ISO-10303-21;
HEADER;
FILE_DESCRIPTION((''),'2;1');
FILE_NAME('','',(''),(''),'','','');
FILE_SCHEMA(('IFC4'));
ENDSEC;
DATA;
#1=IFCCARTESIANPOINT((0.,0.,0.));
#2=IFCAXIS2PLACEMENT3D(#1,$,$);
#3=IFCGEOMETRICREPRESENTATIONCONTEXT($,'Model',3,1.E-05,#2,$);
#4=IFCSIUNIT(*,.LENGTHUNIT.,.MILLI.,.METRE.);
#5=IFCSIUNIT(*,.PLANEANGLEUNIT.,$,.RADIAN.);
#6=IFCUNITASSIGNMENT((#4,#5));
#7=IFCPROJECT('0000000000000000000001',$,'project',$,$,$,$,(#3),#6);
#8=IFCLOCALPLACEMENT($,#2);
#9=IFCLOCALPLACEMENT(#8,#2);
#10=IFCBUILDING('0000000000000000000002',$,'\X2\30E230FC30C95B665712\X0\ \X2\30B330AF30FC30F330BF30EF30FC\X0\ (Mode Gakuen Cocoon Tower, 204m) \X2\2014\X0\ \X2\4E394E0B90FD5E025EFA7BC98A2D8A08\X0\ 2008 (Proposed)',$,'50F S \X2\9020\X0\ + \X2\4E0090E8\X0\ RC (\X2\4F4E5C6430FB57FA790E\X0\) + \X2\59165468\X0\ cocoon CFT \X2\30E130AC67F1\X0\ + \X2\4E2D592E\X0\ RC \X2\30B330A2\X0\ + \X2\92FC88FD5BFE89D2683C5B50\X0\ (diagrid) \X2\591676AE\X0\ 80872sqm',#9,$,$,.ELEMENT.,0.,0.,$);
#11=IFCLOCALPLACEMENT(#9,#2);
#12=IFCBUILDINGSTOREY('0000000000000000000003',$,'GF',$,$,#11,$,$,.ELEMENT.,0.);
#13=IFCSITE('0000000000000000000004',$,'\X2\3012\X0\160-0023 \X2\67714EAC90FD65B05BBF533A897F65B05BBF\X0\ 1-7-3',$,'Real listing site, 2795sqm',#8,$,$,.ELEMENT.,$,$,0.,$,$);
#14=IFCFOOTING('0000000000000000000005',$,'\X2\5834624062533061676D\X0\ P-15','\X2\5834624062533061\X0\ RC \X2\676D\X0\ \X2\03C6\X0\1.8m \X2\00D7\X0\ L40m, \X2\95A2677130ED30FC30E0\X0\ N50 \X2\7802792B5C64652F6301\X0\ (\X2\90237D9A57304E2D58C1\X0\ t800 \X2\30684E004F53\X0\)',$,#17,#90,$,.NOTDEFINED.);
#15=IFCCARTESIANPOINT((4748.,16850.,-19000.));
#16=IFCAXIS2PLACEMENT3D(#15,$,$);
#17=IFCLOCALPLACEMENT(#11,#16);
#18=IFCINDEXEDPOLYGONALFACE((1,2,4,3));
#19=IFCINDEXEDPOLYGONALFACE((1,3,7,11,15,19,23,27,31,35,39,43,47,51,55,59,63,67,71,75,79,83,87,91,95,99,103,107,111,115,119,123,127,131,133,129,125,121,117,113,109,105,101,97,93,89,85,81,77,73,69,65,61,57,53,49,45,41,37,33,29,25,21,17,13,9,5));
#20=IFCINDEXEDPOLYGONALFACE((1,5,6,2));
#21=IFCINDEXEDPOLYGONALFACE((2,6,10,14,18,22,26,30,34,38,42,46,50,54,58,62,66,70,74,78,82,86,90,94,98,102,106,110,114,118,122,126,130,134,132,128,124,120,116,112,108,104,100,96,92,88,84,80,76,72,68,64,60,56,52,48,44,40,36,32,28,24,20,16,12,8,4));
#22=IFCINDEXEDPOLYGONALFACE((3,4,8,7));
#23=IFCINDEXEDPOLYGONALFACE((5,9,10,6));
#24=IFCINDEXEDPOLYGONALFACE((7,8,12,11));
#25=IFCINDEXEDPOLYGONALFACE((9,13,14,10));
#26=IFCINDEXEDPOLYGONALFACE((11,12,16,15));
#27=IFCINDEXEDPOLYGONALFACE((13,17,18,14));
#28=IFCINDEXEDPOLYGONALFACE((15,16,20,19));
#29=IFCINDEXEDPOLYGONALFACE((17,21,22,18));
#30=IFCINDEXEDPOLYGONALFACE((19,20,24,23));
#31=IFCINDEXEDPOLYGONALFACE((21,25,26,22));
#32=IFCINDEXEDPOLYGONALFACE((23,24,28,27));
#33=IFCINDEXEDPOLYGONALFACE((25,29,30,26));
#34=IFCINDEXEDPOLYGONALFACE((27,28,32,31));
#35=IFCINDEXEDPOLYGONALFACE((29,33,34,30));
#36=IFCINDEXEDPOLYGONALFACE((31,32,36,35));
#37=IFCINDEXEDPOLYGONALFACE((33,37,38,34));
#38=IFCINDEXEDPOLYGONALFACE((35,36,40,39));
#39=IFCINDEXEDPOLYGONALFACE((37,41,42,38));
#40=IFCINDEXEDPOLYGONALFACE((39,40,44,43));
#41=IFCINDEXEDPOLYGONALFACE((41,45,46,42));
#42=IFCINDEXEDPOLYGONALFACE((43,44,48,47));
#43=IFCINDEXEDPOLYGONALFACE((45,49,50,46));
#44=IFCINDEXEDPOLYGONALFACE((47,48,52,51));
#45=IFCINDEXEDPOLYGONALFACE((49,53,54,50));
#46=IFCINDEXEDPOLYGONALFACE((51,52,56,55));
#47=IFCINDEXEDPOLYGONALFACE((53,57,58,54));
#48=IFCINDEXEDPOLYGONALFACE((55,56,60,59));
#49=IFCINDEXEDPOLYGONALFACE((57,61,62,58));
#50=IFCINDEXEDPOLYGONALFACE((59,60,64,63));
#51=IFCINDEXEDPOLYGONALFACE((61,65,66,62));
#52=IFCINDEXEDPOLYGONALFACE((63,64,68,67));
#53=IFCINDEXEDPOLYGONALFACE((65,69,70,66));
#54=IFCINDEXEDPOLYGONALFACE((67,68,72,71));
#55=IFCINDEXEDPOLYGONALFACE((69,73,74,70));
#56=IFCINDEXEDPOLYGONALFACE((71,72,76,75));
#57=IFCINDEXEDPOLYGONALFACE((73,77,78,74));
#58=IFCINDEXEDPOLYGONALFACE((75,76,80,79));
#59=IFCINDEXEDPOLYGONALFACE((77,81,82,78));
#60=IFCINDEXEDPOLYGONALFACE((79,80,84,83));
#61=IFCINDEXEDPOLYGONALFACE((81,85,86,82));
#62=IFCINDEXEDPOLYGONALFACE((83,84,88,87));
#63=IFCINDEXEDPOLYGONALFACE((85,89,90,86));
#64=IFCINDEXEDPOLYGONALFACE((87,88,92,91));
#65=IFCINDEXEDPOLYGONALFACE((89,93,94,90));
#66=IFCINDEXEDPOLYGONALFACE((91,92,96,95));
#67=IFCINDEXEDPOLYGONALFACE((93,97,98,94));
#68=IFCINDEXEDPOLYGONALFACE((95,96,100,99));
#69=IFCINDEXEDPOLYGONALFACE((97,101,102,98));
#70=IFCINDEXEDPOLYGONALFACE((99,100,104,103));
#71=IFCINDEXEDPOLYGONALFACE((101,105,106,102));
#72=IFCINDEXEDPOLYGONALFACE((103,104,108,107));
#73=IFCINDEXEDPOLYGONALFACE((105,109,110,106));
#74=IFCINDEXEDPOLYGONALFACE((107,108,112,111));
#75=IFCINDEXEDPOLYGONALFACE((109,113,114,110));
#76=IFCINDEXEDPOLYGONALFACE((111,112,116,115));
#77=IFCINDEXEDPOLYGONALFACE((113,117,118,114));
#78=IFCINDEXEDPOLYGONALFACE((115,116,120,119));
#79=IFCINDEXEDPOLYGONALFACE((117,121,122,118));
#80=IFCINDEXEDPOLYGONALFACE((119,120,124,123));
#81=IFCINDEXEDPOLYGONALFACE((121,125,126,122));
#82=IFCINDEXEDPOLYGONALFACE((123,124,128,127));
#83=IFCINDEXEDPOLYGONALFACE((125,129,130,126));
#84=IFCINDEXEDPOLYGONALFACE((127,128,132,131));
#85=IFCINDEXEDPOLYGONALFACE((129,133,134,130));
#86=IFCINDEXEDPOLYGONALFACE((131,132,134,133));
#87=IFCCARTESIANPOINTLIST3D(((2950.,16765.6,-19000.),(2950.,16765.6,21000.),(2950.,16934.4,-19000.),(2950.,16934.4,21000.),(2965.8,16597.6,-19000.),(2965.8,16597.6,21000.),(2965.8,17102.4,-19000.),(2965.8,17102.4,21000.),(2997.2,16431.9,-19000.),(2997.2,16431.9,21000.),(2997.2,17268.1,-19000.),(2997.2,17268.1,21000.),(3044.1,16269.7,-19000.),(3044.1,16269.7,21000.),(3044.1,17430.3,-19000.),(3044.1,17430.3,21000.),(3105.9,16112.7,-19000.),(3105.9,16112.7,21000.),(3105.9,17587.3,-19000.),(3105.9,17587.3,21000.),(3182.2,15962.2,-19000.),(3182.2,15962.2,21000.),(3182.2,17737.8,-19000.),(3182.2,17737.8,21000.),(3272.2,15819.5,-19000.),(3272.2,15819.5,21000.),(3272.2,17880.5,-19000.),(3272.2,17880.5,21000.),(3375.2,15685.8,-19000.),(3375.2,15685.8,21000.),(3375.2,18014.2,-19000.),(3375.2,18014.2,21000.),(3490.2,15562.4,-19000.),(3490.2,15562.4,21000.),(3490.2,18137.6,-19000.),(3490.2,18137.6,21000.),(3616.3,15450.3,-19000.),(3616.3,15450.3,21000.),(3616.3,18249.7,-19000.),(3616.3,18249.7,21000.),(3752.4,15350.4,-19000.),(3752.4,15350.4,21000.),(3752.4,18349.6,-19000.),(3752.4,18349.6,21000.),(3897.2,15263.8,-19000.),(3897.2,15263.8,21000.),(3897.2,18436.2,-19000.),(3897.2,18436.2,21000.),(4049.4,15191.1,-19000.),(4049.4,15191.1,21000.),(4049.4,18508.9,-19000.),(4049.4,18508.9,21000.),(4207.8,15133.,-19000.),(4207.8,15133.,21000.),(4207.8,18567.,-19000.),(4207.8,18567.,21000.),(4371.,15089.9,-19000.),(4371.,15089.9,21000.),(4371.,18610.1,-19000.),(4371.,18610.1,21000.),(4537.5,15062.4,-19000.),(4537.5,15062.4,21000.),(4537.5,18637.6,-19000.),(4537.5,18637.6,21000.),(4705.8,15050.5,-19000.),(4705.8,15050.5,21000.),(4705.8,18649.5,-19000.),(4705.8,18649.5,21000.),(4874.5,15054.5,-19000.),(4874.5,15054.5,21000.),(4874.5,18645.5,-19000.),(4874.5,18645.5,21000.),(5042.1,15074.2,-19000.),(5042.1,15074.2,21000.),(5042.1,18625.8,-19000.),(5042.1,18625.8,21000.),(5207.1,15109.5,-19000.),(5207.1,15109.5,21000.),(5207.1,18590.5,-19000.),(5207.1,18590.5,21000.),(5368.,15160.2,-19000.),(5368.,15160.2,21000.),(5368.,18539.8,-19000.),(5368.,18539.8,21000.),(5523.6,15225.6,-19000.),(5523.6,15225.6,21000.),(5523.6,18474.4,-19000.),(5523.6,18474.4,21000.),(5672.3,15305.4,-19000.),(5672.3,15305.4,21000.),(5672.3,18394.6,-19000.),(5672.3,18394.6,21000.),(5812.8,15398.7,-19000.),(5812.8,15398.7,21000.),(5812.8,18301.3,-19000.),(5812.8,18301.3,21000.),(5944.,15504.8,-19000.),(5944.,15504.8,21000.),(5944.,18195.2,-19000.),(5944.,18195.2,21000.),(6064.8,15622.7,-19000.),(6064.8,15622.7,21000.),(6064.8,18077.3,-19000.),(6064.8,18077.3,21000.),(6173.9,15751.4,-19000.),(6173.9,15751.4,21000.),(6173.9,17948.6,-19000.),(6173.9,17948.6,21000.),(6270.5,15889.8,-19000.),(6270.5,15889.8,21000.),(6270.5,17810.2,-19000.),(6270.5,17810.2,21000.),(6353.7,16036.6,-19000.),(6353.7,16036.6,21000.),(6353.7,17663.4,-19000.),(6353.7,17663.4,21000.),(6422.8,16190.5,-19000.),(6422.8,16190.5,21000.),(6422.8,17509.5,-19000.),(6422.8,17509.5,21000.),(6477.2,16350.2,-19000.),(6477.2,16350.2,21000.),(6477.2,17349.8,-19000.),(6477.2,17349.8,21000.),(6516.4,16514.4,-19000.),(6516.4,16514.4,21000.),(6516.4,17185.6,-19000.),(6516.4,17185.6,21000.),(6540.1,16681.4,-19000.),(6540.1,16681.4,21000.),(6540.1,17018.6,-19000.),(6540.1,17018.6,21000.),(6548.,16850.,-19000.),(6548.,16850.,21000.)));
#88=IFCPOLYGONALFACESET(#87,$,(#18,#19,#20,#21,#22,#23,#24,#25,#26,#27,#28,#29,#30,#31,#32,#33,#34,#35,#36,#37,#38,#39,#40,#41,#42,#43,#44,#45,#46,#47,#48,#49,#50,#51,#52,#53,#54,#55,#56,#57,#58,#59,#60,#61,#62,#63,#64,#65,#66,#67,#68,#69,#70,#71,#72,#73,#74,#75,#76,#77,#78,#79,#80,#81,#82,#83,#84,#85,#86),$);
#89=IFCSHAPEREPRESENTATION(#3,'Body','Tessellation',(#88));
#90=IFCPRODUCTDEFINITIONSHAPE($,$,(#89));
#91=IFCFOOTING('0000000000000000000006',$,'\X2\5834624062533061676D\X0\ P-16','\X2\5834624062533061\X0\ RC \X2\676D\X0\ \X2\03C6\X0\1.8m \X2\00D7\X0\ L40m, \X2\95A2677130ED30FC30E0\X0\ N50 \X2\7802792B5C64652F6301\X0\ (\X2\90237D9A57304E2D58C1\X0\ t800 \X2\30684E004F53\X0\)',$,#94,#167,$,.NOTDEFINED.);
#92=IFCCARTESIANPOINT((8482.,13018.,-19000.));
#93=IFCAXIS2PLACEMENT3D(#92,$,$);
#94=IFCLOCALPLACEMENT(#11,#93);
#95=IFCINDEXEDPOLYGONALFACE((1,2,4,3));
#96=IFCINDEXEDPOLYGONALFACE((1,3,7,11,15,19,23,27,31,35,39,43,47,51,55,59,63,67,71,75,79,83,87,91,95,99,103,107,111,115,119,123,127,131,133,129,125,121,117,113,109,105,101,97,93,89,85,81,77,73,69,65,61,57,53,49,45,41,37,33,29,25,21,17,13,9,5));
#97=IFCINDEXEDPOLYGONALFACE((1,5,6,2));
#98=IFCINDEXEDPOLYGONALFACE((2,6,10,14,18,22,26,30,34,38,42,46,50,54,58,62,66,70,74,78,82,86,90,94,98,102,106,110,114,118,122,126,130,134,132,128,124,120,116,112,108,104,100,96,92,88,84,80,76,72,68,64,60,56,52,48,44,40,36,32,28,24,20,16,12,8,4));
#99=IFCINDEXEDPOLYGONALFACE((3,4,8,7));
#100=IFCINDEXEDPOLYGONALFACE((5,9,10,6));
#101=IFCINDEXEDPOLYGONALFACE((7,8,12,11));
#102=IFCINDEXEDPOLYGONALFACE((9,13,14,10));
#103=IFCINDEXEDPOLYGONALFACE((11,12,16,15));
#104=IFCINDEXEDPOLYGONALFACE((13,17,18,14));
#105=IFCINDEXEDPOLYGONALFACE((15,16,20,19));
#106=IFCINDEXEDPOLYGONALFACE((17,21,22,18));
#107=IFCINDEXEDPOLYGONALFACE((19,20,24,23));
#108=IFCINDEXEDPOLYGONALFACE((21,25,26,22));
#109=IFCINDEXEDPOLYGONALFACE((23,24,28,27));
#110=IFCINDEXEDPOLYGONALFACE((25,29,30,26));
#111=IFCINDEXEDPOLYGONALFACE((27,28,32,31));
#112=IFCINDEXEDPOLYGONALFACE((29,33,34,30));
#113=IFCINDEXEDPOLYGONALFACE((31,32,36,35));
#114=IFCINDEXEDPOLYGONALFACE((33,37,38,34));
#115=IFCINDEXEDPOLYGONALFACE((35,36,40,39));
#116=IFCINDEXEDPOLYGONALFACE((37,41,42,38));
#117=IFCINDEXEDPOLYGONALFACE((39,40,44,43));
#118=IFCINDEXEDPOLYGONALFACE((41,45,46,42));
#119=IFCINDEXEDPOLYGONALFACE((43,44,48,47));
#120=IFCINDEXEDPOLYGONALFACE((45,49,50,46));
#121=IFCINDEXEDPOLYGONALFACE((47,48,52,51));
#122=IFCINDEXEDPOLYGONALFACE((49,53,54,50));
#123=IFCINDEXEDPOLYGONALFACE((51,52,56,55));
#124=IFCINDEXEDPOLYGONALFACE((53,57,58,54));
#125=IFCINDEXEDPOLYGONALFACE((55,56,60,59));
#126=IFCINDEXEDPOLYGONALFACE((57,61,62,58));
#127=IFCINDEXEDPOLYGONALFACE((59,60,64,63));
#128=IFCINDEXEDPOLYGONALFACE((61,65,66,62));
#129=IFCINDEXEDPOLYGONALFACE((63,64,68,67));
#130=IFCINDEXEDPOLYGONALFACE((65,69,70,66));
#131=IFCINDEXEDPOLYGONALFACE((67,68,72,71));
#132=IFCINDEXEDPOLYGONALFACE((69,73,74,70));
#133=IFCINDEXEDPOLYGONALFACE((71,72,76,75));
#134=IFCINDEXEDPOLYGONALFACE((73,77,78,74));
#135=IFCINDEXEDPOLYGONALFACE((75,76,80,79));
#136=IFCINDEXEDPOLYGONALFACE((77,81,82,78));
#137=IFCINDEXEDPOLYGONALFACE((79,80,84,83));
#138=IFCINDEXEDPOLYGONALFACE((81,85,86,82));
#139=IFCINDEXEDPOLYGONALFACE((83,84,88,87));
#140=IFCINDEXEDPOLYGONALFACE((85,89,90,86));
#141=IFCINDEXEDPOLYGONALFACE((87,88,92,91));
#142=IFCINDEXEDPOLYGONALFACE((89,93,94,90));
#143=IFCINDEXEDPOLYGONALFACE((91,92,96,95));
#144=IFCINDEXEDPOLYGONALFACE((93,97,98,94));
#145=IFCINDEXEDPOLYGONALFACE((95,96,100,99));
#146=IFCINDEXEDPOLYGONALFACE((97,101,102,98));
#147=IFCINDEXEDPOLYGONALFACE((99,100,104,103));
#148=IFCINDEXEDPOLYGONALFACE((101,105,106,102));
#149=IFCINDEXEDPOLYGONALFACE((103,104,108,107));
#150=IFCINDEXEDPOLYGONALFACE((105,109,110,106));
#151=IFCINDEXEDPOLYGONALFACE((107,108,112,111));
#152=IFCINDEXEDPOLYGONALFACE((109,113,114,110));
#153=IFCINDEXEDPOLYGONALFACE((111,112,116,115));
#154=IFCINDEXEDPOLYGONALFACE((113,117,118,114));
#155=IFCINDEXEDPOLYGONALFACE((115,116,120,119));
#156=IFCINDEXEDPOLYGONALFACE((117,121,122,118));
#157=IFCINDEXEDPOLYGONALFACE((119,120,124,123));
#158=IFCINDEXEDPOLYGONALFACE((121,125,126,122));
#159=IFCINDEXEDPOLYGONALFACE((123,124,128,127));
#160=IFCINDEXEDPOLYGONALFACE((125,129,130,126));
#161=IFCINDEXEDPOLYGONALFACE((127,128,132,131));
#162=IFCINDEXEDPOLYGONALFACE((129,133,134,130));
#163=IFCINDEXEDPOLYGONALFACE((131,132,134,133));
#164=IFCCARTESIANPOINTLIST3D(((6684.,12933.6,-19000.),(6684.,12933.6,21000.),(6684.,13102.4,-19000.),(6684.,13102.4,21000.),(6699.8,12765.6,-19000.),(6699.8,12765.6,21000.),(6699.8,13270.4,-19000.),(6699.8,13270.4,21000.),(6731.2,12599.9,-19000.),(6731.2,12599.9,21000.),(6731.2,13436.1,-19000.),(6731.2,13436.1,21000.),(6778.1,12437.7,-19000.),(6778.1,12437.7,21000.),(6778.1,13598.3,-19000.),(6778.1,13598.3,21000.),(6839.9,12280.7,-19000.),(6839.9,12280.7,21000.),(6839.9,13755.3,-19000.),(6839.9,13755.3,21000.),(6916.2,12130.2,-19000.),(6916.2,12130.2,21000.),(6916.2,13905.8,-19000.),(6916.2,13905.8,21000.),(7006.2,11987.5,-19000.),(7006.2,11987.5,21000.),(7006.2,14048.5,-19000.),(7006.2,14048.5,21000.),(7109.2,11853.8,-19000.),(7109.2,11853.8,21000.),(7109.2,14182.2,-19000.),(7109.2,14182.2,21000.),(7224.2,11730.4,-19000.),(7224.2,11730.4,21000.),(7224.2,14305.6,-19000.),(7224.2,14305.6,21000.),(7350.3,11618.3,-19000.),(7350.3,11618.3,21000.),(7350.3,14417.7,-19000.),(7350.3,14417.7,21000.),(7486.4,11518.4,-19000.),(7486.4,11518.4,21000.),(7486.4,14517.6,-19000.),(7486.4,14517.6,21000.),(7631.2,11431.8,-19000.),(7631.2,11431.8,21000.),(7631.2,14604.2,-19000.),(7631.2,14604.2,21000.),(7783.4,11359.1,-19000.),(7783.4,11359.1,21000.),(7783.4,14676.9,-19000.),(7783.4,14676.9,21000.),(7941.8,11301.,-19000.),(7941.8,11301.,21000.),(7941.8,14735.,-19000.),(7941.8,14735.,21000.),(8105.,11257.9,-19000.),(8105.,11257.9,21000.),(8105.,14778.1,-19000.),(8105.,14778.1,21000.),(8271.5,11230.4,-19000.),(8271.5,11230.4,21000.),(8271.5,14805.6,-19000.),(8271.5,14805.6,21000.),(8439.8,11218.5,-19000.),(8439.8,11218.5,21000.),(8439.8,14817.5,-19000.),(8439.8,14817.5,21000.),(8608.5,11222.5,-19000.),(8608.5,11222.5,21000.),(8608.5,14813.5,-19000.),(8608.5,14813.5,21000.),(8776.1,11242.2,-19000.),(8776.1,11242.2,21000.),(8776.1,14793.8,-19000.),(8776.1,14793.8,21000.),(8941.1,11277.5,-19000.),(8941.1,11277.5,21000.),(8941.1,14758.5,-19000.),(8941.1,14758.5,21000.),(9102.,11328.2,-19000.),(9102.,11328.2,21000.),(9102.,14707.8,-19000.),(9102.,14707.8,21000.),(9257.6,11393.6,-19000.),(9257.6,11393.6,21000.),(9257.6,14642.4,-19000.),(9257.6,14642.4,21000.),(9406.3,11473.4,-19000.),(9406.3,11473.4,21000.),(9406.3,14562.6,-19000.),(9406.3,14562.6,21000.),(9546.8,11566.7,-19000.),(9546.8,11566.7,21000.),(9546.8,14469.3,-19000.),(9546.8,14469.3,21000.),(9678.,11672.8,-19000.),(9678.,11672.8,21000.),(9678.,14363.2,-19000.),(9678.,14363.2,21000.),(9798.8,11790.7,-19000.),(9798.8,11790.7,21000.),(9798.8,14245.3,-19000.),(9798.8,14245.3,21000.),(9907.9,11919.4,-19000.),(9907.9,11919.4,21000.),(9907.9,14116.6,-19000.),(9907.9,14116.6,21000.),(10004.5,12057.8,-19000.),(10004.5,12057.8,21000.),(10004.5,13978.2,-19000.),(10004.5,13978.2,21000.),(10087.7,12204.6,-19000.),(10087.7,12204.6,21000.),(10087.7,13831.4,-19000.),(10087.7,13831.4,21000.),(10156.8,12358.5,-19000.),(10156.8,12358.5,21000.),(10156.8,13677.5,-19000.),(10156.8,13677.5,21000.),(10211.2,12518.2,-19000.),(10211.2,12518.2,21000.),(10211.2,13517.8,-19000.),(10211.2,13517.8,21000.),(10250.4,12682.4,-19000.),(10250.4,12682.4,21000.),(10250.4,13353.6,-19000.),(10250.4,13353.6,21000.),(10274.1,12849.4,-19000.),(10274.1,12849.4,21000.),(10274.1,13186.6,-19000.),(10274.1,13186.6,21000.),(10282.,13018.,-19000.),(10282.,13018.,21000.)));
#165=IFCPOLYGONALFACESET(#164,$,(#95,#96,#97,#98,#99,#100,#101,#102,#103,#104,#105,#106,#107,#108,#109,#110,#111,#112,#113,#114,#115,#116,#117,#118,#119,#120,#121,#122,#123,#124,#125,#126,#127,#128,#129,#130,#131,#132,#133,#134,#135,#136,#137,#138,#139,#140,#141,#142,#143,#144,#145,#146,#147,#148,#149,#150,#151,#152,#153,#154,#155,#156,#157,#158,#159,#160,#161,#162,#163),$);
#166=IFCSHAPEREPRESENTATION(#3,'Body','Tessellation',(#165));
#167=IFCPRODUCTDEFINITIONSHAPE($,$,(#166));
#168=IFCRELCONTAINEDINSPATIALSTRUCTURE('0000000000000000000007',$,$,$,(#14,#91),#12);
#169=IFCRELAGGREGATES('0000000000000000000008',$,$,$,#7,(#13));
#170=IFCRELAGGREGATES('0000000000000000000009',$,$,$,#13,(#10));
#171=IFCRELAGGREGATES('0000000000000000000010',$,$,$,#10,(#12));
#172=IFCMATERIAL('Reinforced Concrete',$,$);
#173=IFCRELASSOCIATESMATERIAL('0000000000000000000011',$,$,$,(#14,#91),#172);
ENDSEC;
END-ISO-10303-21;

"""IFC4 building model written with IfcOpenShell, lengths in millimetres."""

from ifc_helpers import new_model, si_unit, frame, origin, origin_2d, place, context, project, spatial, circle, extrude, material, element, save


model = new_model("IFC4")

# Units and contexts
model_context = context("Model", 3, precision=1e-05, world=origin())
ifc_project = project(units=[si_unit("LENGTHUNIT", "METRE", prefix="MILLI"), si_unit("PLANEANGLEUNIT", "RADIAN")], contexts=[model_context])

# Site, building, storey
site_placement = place(None, origin())
site = spatial("IfcSite", under=ifc_project, at=site_placement, Name="〒160-0023 東京都新宿区西新宿 1-7-3", ObjectType="Real listing site, 2795sqm", CompositionType="ELEMENT", RefElevation=0.0)
building_placement = place(site_placement, origin())
building = spatial("IfcBuilding", under=site, at=building_placement, Name="モード学園 コクーンタワー (Mode Gakuen Cocoon Tower, 204m) — 丹下都市建築設計 2008 (Proposed)", ObjectType="50F S 造 + 一部 RC (低層・基礎) + 外周 cocoon CFT メガ柱 + 中央 RC コア + 鋼製対角格子 (diagrid) 外皮 80872sqm", CompositionType="ELEMENT", ElevationOfRefHeight=0.0, ElevationOfTerrain=0.0)
storey_placement = place(building_placement, origin())
storey = spatial("IfcBuildingStorey", under=building, at=storey_placement, Name="GF", CompositionType="ELEMENT", Elevation=0.0)

# Footings
ifc_material_1 = material(Name="Reinforced Concrete")
footing_1_placement = place(storey_placement, frame((4748.0, 16850.0, -19000.0)))
element("IfcFooting", 1, at=footing_1_placement, inside=storey, material=ifc_material_1, Name="場所打ち杭 P-15", Description="場所打ち RC 杭 φ1.8m × L40m, 関東ローム N50 砂礫層支持 (連続地中壁 t800 と一体)", PredefinedType="NOTDEFINED", context=model_context, shape_type="SweptSolid", body=[
    extrude(circle(Radius=1800.0, at=origin_2d()), frame((4748.0, 16850.0, -19000.0)), (0.0, 0.0, 1.0), 40000.0),
])
footing_2_placement = place(storey_placement, frame((8482.0, 13018.0, -19000.0)))
element("IfcFooting", 2, at=footing_2_placement, inside=storey, material=ifc_material_1, Name="場所打ち杭 P-16", Description="場所打ち RC 杭 φ1.8m × L40m, 関東ローム N50 砂礫層支持 (連続地中壁 t800 と一体)", PredefinedType="NOTDEFINED", context=model_context, shape_type="SweptSolid", body=[
    extrude(circle(Radius=1800.0, at=origin_2d()), frame((8482.0, 13018.0, -19000.0)), (0.0, 0.0, 1.0), 40000.0),
])

save(model, "model.ifc")
